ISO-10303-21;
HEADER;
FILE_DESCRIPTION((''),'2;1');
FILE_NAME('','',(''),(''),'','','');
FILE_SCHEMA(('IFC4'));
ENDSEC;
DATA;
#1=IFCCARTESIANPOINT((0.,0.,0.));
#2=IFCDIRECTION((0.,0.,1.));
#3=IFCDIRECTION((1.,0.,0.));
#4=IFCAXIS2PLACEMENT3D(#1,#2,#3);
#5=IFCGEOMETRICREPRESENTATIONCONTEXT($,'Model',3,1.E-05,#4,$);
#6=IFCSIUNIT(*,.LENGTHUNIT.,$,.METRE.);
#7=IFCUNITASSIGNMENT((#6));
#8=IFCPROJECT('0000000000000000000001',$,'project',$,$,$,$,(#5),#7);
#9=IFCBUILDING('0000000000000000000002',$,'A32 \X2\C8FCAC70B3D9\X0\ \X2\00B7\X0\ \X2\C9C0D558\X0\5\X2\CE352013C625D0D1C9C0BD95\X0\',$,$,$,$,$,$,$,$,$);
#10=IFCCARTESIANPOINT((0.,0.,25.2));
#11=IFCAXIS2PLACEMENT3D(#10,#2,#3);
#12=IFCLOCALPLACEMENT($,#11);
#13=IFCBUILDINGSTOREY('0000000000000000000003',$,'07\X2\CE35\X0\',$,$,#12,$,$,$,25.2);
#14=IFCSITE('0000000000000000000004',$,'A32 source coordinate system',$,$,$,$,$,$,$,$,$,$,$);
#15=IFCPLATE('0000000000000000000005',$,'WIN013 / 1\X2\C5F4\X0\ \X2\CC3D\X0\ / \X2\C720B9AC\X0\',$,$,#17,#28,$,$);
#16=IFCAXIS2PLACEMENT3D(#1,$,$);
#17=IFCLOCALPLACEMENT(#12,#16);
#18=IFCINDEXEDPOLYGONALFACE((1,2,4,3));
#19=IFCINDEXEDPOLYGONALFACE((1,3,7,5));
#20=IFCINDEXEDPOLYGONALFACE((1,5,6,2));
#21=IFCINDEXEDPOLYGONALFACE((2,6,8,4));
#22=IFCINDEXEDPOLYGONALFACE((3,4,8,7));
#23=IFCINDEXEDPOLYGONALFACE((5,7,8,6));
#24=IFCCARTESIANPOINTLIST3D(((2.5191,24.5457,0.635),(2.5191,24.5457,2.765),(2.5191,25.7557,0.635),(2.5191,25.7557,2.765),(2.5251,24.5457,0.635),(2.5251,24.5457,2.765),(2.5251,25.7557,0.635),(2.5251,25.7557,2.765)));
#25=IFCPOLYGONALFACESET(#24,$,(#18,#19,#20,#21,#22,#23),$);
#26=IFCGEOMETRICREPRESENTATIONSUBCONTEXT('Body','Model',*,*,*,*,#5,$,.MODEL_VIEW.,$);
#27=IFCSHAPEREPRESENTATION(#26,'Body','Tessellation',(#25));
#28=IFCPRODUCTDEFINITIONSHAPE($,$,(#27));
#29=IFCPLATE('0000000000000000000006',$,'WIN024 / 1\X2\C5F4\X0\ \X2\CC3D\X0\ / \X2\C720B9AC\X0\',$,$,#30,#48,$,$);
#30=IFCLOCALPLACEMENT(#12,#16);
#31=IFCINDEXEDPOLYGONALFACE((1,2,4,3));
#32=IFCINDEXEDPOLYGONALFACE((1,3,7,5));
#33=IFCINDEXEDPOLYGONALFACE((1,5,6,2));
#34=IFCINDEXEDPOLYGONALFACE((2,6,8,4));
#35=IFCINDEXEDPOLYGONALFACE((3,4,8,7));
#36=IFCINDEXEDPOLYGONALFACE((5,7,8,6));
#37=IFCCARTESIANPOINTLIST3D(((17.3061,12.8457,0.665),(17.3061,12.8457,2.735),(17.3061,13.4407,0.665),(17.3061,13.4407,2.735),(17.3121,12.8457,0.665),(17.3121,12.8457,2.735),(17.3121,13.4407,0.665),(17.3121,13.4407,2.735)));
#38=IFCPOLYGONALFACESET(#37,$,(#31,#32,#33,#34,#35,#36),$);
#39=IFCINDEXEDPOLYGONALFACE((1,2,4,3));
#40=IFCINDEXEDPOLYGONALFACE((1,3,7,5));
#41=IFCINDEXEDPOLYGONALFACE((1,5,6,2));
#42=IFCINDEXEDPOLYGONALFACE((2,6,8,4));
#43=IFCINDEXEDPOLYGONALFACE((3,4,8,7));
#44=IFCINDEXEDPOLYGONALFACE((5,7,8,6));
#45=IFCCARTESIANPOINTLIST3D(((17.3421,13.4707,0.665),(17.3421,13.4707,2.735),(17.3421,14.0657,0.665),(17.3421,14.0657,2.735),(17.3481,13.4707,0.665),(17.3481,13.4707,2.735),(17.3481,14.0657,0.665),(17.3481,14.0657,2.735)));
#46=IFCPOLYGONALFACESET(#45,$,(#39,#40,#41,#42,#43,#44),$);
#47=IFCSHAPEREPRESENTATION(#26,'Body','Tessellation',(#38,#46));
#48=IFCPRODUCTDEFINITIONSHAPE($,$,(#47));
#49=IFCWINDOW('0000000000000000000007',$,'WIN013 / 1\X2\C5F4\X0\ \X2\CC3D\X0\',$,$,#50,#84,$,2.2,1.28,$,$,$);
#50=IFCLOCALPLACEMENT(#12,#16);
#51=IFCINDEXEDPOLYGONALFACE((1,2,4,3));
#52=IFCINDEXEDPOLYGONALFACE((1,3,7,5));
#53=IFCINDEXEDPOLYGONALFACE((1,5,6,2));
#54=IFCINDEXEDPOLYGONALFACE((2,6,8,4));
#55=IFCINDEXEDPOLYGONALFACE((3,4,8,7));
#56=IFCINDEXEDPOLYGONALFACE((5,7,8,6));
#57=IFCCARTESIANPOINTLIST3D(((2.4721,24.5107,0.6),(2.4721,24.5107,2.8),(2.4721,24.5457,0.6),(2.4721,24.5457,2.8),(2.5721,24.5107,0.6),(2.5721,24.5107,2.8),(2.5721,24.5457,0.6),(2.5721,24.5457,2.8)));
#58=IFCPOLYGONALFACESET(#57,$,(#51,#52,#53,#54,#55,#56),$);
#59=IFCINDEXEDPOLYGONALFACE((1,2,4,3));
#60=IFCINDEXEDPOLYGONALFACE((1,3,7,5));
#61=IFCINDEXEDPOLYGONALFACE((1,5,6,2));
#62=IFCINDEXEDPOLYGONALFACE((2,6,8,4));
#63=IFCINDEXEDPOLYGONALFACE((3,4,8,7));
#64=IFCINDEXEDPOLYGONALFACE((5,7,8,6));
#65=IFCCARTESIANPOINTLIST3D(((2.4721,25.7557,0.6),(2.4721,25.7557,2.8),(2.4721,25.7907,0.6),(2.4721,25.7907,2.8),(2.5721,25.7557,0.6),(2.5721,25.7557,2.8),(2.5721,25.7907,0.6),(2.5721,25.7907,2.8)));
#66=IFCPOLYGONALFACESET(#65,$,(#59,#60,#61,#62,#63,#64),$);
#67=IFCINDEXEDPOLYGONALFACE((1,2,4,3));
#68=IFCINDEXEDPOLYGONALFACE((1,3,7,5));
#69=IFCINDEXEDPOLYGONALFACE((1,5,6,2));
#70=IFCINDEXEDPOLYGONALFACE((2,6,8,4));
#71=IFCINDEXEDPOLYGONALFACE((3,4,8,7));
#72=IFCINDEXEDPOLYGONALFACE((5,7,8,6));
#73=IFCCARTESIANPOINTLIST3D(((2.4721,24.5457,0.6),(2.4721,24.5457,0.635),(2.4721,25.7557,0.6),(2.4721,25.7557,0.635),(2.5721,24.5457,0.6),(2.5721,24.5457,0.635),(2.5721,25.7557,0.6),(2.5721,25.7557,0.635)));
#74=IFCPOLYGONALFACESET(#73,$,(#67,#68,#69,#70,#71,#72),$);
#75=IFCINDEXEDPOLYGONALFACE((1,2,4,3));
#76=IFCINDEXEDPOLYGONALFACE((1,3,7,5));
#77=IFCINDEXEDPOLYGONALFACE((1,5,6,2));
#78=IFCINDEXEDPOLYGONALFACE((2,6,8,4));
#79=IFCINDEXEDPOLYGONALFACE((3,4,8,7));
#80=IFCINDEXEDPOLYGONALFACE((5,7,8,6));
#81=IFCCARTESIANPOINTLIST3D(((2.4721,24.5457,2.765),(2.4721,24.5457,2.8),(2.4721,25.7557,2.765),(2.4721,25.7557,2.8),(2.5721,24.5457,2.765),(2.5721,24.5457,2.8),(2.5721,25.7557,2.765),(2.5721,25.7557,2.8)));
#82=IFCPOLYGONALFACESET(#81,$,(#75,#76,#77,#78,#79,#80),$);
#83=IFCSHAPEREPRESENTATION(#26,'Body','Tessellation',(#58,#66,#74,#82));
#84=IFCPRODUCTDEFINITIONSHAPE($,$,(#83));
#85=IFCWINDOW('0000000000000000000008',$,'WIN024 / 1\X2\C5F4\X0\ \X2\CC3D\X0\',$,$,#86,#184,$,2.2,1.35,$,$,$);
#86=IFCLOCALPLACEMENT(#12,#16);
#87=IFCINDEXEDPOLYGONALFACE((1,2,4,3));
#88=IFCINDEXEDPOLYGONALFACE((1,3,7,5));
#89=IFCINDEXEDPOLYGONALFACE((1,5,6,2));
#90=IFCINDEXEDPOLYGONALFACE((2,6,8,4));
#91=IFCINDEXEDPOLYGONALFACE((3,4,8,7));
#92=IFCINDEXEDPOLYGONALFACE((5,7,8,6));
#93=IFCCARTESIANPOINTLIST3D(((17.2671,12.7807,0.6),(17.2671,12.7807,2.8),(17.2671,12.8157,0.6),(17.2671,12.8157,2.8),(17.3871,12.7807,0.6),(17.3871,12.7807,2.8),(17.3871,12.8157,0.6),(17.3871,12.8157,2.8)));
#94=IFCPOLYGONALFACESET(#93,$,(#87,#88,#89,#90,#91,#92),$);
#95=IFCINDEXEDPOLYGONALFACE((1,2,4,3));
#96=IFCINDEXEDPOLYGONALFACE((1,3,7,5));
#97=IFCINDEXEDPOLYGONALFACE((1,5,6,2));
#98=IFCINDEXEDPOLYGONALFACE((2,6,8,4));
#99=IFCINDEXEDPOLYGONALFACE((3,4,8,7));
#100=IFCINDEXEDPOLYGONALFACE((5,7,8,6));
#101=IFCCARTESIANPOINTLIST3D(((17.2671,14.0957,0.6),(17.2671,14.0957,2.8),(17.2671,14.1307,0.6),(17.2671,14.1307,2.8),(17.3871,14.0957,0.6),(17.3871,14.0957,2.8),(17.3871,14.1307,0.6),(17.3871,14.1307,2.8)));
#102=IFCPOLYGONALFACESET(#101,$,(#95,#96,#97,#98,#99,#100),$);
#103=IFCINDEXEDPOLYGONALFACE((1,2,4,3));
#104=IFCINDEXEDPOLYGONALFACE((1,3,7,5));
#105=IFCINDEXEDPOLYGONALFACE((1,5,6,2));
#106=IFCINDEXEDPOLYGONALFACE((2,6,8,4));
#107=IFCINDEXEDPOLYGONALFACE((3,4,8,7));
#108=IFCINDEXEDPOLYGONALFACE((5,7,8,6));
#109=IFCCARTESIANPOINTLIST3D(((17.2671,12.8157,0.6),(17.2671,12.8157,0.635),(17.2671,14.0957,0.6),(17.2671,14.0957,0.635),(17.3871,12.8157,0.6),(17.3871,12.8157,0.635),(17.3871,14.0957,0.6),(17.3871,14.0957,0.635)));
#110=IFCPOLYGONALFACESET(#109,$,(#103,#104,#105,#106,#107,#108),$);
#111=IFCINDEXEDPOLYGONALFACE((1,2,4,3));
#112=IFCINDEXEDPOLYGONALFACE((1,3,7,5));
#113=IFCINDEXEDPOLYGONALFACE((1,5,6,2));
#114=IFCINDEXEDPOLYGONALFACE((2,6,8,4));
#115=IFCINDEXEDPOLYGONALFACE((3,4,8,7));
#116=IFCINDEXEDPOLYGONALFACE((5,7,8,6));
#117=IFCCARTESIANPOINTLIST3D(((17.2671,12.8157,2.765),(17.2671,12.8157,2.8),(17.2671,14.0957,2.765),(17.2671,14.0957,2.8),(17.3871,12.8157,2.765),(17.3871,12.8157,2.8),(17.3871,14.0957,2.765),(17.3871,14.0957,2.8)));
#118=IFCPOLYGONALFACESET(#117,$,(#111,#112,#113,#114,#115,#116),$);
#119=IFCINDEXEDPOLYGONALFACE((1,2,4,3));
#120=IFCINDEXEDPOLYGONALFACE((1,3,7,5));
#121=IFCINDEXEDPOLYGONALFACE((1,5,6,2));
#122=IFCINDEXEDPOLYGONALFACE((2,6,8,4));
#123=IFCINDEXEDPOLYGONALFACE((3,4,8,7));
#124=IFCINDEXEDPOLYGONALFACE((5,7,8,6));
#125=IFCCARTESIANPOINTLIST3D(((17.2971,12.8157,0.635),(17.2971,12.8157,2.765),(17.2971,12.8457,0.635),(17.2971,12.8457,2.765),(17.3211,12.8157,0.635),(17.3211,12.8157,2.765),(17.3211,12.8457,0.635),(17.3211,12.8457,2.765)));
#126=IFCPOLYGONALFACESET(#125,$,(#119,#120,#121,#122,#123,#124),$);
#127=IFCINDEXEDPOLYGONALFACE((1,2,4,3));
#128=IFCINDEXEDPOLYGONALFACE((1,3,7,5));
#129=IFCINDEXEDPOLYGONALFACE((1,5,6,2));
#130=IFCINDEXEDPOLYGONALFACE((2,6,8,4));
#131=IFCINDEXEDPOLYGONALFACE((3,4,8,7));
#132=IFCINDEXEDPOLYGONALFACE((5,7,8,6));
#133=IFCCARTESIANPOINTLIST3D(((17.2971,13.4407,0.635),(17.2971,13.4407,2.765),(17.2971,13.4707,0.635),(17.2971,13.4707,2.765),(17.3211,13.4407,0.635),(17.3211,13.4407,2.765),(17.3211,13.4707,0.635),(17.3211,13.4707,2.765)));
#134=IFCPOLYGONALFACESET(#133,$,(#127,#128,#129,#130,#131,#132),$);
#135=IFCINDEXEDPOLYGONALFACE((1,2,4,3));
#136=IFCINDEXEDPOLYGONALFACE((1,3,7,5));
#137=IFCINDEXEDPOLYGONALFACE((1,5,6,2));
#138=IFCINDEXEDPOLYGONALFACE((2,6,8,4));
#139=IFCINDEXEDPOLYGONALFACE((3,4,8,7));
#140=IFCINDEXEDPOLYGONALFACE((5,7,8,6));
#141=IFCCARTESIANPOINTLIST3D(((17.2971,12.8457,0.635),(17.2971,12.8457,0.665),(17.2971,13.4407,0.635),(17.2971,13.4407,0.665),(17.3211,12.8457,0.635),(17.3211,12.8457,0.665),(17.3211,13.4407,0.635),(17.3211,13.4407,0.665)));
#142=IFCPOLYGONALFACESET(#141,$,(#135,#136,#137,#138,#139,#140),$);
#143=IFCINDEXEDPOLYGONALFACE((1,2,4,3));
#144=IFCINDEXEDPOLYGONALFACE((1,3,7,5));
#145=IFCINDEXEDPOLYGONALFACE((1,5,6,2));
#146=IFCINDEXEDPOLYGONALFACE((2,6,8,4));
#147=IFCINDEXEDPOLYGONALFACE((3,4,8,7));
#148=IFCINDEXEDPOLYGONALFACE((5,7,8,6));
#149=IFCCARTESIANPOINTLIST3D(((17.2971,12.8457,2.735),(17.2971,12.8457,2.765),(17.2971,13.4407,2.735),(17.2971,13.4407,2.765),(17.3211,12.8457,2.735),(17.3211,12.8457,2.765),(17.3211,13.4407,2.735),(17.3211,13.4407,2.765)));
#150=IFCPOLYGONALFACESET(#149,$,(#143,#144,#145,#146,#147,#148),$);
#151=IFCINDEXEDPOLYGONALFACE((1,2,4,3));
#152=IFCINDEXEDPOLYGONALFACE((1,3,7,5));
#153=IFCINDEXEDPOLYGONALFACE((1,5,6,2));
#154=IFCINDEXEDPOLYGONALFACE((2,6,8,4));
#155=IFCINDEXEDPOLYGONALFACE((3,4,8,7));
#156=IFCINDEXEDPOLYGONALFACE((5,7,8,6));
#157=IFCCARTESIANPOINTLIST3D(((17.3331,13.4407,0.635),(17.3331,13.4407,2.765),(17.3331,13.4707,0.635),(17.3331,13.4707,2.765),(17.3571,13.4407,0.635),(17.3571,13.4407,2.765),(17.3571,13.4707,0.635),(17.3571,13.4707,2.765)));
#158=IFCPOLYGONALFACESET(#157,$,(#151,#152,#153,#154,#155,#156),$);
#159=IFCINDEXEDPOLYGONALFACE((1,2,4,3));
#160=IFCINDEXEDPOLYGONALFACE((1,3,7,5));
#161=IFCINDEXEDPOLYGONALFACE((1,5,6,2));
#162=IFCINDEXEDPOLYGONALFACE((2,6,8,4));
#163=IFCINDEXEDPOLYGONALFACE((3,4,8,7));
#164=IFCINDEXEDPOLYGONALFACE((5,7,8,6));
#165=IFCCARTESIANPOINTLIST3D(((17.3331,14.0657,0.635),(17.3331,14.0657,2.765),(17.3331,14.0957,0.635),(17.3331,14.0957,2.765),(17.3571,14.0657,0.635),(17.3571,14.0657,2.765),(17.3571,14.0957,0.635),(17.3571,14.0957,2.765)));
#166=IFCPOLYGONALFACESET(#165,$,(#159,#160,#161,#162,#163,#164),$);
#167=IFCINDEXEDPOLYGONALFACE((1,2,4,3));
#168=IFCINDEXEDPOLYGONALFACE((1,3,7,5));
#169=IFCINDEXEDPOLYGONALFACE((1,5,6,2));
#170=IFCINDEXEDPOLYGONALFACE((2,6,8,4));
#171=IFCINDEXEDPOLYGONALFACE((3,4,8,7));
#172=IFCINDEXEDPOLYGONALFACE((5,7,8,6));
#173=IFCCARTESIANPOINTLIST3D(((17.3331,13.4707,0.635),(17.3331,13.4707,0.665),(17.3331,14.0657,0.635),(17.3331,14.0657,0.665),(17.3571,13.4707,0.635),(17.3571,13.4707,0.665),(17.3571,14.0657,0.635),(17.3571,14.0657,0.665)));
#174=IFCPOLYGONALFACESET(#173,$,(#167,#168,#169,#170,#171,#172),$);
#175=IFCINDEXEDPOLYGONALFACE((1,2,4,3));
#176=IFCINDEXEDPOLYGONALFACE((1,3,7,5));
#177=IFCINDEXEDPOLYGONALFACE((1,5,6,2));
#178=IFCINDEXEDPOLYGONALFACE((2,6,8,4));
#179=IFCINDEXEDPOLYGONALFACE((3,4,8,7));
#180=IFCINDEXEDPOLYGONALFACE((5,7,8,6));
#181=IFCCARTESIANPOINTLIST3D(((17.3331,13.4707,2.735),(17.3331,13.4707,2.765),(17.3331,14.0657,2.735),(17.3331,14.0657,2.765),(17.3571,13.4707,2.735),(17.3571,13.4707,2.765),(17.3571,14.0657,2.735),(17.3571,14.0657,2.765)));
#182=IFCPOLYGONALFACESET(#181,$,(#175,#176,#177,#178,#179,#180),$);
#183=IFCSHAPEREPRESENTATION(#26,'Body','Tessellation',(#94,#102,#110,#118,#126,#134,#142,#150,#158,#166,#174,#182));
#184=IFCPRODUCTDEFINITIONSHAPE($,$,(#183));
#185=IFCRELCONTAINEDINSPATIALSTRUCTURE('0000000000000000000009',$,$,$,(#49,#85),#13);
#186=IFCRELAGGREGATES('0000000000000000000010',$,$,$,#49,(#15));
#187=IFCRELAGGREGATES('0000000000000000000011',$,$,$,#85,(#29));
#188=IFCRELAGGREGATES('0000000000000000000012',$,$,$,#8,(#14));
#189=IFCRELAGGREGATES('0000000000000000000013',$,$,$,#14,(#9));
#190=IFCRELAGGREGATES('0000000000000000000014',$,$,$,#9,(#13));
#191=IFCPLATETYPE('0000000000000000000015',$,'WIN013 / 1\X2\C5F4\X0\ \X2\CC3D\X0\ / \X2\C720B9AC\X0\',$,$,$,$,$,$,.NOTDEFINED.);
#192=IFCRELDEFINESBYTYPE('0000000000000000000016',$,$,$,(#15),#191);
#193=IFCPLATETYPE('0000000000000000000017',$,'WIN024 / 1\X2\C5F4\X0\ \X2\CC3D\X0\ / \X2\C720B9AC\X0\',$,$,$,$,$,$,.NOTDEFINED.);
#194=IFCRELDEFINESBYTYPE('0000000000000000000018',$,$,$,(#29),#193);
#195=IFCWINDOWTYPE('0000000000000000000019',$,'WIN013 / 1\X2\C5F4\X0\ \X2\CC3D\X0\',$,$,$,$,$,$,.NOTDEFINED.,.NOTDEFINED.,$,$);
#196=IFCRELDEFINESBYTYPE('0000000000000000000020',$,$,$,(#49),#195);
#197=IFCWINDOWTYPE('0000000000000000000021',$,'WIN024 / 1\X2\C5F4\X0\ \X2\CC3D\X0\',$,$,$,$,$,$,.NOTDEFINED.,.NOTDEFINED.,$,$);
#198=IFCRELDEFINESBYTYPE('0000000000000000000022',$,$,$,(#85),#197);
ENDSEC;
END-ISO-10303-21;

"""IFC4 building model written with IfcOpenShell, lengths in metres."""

from ifc_helpers import new_model, si_unit, frame, origin, origin_with_axes, place, context, subcontext, project, spatial, polyline, outline, extrude, source, transform, mapped, type_object, type_shapes, element, aggregate, save


model = new_model("IFC4")

# Units and contexts
model_context = context("Model", 3, precision=1e-05, world=origin_with_axes())
body_context = subcontext(model_context, "Body", "Model", "MODEL_VIEW")
ifc_project = project(units=[si_unit("LENGTHUNIT", "METRE")], contexts=[model_context])

# Plates
plate_type_1 = type_object("IfcPlateType", Name="WIN013 / 1열 창 / 유리", PredefinedType="NOTDEFINED")
shared_shape_1 = source(origin(), body_context, "Body", "SweptSolid", [
    extrude(outline(polyline([(2.5191, 24.5457), (2.5191, 25.7557), (2.5251, 25.7557), (2.5251, 24.5457), (2.5191, 24.5457)])), frame((0.0, 0.0, 0.635)), (0.0, 0.0, 1.0), 2.13),
])
type_shapes(plate_type_1, [shared_shape_1])
storey_placement = place(None, frame((0.0, 0.0, 25.2), z_axis=(0.0, 0.0, 1.0), x_axis=(1.0, 0.0, 0.0)))
window_1_placement = place(storey_placement, origin_with_axes())
plate_1_placement = place(window_1_placement, origin_with_axes())
plate_1 = element("IfcPlate", 1, at=plate_1_placement, type_object=plate_type_1, Name="WIN013 / 1열 창 / 유리", context=body_context, shape_type="MappedRepresentation", body=[
    mapped(shared_shape_1, transform((0.0, 0.0, 0.0), scale=1.0)),
])
plate_type_2 = type_object("IfcPlateType", Name="WIN024 / 1열 창 / 유리", PredefinedType="NOTDEFINED")
shared_shape_2 = source(origin(), body_context, "Body", "SweptSolid", [
    extrude(outline(polyline([(17.3061, 12.8457), (17.3061, 13.4407), (17.3121, 13.4407), (17.3121, 12.8457), (17.3061, 12.8457)])), frame((0.0, 0.0, 0.665)), (0.0, 0.0, 1.0), 2.07),
    extrude(outline(polyline([(17.3421, 13.4707), (17.3421, 14.0657), (17.3481, 14.0657), (17.3481, 13.4707), (17.3421, 13.4707)])), frame((0.0, 0.0, 0.665)), (0.0, 0.0, 1.0), 2.07),
])
type_shapes(plate_type_2, [shared_shape_2])
window_2_placement = place(storey_placement, origin_with_axes())
plate_2_placement = place(window_2_placement, origin_with_axes())
plate_2 = element("IfcPlate", 2, at=plate_2_placement, type_object=plate_type_2, Name="WIN024 / 1열 창 / 유리", context=body_context, shape_type="MappedRepresentation", body=[
    mapped(shared_shape_2, transform((0.0, 0.0, 0.0), scale=1.0)),
])

# Site, building, storey
site = spatial("IfcSite", under=ifc_project, Name="A32 source coordinate system")
building = spatial("IfcBuilding", under=site, Name="A32 주거동 · 지하5층–옥탑지붕")
storey = spatial("IfcBuildingStorey", under=building, at=storey_placement, Name="07층", Elevation=25.2)

# Windows
window_type_1 = type_object("IfcWindowType", Name="WIN013 / 1열 창", PartitioningType="NOTDEFINED", PredefinedType="NOTDEFINED")
shared_shape_3 = source(origin(), body_context, "Body", "SweptSolid", [
    extrude(outline(polyline([(2.4721, 24.5107), (2.4721, 24.5457), (2.5721, 24.5457), (2.5721, 24.5107), (2.4721, 24.5107)])), frame((0.0, 0.0, 0.6)), (0.0, 0.0, 1.0), 2.2),
    extrude(outline(polyline([(2.4721, 25.7557), (2.4721, 25.7907), (2.5721, 25.7907), (2.5721, 25.7557), (2.4721, 25.7557)])), frame((0.0, 0.0, 0.6)), (0.0, 0.0, 1.0), 2.2),
    extrude(outline(polyline([(2.4721, 24.5457), (2.4721, 25.7557), (2.5721, 25.7557), (2.5721, 24.5457), (2.4721, 24.5457)])), frame((0.0, 0.0, 0.6)), (0.0, 0.0, 1.0), 0.035),
    extrude(outline(polyline([(2.4721, 24.5457), (2.4721, 25.7557), (2.5721, 25.7557), (2.5721, 24.5457), (2.4721, 24.5457)])), frame((0.0, 0.0, 2.765)), (0.0, 0.0, 1.0), 0.035),
])
type_shapes(window_type_1, [shared_shape_3])
window_1 = element("IfcWindow", 3, at=window_1_placement, inside=storey, type_object=window_type_1, Name="WIN013 / 1열 창", OverallHeight=2.2, OverallWidth=1.28, context=body_context, shape_type="MappedRepresentation", body=[
    mapped(shared_shape_3, transform((0.0, 0.0, 0.0), scale=1.0)),
])
aggregate(window_1, [plate_1])
window_type_2 = type_object("IfcWindowType", Name="WIN024 / 1열 창", PartitioningType="NOTDEFINED", PredefinedType="NOTDEFINED")
shared_shape_4 = source(origin(), body_context, "Body", "SweptSolid", [
    extrude(outline(polyline([(17.2671, 12.7807), (17.2671, 12.8157), (17.3871, 12.8157), (17.3871, 12.7807), (17.2671, 12.7807)])), frame((0.0, 0.0, 0.6)), (0.0, 0.0, 1.0), 2.2),
    extrude(outline(polyline([(17.2671, 14.0957), (17.2671, 14.1307), (17.3871, 14.1307), (17.3871, 14.0957), (17.2671, 14.0957)])), frame((0.0, 0.0, 0.6)), (0.0, 0.0, 1.0), 2.2),
    extrude(outline(polyline([(17.2671, 12.8157), (17.2671, 14.0957), (17.3871, 14.0957), (17.3871, 12.8157), (17.2671, 12.8157)])), frame((0.0, 0.0, 0.6)), (0.0, 0.0, 1.0), 0.035),
    extrude(outline(polyline([(17.2671, 12.8157), (17.2671, 14.0957), (17.3871, 14.0957), (17.3871, 12.8157), (17.2671, 12.8157)])), frame((0.0, 0.0, 2.765)), (0.0, 0.0, 1.0), 0.035),
    extrude(outline(polyline([(17.2971, 12.8157), (17.2971, 12.8457), (17.3211, 12.8457), (17.3211, 12.8157), (17.2971, 12.8157)])), frame((0.0, 0.0, 0.635)), (0.0, 0.0, 1.0), 2.13),
    extrude(outline(polyline([(17.2971, 13.4407), (17.2971, 13.4707), (17.3211, 13.4707), (17.3211, 13.4407), (17.2971, 13.4407)])), frame((0.0, 0.0, 0.635)), (0.0, 0.0, 1.0), 2.13),
    extrude(outline(polyline([(17.2971, 12.8457), (17.2971, 13.4407), (17.3211, 13.4407), (17.3211, 12.8457), (17.2971, 12.8457)])), frame((0.0, 0.0, 0.635)), (0.0, 0.0, 1.0), 0.03),
    extrude(outline(polyline([(17.2971, 12.8457), (17.2971, 13.4407), (17.3211, 13.4407), (17.3211, 12.8457), (17.2971, 12.8457)])), frame((0.0, 0.0, 2.735)), (0.0, 0.0, 1.0), 0.03),
    extrude(outline(polyline([(17.3331, 13.4407), (17.3331, 13.4707), (17.3571, 13.4707), (17.3571, 13.4407), (17.3331, 13.4407)])), frame((0.0, 0.0, 0.635)), (0.0, 0.0, 1.0), 2.13),
    extrude(outline(polyline([(17.3331, 14.0657), (17.3331, 14.0957), (17.3571, 14.0957), (17.3571, 14.0657), (17.3331, 14.0657)])), frame((0.0, 0.0, 0.635)), (0.0, 0.0, 1.0), 2.13),
    extrude(outline(polyline([(17.3331, 13.4707), (17.3331, 14.0657), (17.3571, 14.0657), (17.3571, 13.4707), (17.3331, 13.4707)])), frame((0.0, 0.0, 0.635)), (0.0, 0.0, 1.0), 0.03),
    extrude(outline(polyline([(17.3331, 13.4707), (17.3331, 14.0657), (17.3571, 14.0657), (17.3571, 13.4707), (17.3331, 13.4707)])), frame((0.0, 0.0, 2.735)), (0.0, 0.0, 1.0), 0.03),
])
type_shapes(window_type_2, [shared_shape_4])
window_2 = element("IfcWindow", 4, at=window_2_placement, inside=storey, type_object=window_type_2, Name="WIN024 / 1열 창", OverallHeight=2.2, OverallWidth=1.35, context=body_context, shape_type="MappedRepresentation", body=[
    mapped(shared_shape_4, transform((0.0, 0.0, 0.0), scale=1.0)),
])
aggregate(window_2, [plate_2])

save(model, "model.ifc")
